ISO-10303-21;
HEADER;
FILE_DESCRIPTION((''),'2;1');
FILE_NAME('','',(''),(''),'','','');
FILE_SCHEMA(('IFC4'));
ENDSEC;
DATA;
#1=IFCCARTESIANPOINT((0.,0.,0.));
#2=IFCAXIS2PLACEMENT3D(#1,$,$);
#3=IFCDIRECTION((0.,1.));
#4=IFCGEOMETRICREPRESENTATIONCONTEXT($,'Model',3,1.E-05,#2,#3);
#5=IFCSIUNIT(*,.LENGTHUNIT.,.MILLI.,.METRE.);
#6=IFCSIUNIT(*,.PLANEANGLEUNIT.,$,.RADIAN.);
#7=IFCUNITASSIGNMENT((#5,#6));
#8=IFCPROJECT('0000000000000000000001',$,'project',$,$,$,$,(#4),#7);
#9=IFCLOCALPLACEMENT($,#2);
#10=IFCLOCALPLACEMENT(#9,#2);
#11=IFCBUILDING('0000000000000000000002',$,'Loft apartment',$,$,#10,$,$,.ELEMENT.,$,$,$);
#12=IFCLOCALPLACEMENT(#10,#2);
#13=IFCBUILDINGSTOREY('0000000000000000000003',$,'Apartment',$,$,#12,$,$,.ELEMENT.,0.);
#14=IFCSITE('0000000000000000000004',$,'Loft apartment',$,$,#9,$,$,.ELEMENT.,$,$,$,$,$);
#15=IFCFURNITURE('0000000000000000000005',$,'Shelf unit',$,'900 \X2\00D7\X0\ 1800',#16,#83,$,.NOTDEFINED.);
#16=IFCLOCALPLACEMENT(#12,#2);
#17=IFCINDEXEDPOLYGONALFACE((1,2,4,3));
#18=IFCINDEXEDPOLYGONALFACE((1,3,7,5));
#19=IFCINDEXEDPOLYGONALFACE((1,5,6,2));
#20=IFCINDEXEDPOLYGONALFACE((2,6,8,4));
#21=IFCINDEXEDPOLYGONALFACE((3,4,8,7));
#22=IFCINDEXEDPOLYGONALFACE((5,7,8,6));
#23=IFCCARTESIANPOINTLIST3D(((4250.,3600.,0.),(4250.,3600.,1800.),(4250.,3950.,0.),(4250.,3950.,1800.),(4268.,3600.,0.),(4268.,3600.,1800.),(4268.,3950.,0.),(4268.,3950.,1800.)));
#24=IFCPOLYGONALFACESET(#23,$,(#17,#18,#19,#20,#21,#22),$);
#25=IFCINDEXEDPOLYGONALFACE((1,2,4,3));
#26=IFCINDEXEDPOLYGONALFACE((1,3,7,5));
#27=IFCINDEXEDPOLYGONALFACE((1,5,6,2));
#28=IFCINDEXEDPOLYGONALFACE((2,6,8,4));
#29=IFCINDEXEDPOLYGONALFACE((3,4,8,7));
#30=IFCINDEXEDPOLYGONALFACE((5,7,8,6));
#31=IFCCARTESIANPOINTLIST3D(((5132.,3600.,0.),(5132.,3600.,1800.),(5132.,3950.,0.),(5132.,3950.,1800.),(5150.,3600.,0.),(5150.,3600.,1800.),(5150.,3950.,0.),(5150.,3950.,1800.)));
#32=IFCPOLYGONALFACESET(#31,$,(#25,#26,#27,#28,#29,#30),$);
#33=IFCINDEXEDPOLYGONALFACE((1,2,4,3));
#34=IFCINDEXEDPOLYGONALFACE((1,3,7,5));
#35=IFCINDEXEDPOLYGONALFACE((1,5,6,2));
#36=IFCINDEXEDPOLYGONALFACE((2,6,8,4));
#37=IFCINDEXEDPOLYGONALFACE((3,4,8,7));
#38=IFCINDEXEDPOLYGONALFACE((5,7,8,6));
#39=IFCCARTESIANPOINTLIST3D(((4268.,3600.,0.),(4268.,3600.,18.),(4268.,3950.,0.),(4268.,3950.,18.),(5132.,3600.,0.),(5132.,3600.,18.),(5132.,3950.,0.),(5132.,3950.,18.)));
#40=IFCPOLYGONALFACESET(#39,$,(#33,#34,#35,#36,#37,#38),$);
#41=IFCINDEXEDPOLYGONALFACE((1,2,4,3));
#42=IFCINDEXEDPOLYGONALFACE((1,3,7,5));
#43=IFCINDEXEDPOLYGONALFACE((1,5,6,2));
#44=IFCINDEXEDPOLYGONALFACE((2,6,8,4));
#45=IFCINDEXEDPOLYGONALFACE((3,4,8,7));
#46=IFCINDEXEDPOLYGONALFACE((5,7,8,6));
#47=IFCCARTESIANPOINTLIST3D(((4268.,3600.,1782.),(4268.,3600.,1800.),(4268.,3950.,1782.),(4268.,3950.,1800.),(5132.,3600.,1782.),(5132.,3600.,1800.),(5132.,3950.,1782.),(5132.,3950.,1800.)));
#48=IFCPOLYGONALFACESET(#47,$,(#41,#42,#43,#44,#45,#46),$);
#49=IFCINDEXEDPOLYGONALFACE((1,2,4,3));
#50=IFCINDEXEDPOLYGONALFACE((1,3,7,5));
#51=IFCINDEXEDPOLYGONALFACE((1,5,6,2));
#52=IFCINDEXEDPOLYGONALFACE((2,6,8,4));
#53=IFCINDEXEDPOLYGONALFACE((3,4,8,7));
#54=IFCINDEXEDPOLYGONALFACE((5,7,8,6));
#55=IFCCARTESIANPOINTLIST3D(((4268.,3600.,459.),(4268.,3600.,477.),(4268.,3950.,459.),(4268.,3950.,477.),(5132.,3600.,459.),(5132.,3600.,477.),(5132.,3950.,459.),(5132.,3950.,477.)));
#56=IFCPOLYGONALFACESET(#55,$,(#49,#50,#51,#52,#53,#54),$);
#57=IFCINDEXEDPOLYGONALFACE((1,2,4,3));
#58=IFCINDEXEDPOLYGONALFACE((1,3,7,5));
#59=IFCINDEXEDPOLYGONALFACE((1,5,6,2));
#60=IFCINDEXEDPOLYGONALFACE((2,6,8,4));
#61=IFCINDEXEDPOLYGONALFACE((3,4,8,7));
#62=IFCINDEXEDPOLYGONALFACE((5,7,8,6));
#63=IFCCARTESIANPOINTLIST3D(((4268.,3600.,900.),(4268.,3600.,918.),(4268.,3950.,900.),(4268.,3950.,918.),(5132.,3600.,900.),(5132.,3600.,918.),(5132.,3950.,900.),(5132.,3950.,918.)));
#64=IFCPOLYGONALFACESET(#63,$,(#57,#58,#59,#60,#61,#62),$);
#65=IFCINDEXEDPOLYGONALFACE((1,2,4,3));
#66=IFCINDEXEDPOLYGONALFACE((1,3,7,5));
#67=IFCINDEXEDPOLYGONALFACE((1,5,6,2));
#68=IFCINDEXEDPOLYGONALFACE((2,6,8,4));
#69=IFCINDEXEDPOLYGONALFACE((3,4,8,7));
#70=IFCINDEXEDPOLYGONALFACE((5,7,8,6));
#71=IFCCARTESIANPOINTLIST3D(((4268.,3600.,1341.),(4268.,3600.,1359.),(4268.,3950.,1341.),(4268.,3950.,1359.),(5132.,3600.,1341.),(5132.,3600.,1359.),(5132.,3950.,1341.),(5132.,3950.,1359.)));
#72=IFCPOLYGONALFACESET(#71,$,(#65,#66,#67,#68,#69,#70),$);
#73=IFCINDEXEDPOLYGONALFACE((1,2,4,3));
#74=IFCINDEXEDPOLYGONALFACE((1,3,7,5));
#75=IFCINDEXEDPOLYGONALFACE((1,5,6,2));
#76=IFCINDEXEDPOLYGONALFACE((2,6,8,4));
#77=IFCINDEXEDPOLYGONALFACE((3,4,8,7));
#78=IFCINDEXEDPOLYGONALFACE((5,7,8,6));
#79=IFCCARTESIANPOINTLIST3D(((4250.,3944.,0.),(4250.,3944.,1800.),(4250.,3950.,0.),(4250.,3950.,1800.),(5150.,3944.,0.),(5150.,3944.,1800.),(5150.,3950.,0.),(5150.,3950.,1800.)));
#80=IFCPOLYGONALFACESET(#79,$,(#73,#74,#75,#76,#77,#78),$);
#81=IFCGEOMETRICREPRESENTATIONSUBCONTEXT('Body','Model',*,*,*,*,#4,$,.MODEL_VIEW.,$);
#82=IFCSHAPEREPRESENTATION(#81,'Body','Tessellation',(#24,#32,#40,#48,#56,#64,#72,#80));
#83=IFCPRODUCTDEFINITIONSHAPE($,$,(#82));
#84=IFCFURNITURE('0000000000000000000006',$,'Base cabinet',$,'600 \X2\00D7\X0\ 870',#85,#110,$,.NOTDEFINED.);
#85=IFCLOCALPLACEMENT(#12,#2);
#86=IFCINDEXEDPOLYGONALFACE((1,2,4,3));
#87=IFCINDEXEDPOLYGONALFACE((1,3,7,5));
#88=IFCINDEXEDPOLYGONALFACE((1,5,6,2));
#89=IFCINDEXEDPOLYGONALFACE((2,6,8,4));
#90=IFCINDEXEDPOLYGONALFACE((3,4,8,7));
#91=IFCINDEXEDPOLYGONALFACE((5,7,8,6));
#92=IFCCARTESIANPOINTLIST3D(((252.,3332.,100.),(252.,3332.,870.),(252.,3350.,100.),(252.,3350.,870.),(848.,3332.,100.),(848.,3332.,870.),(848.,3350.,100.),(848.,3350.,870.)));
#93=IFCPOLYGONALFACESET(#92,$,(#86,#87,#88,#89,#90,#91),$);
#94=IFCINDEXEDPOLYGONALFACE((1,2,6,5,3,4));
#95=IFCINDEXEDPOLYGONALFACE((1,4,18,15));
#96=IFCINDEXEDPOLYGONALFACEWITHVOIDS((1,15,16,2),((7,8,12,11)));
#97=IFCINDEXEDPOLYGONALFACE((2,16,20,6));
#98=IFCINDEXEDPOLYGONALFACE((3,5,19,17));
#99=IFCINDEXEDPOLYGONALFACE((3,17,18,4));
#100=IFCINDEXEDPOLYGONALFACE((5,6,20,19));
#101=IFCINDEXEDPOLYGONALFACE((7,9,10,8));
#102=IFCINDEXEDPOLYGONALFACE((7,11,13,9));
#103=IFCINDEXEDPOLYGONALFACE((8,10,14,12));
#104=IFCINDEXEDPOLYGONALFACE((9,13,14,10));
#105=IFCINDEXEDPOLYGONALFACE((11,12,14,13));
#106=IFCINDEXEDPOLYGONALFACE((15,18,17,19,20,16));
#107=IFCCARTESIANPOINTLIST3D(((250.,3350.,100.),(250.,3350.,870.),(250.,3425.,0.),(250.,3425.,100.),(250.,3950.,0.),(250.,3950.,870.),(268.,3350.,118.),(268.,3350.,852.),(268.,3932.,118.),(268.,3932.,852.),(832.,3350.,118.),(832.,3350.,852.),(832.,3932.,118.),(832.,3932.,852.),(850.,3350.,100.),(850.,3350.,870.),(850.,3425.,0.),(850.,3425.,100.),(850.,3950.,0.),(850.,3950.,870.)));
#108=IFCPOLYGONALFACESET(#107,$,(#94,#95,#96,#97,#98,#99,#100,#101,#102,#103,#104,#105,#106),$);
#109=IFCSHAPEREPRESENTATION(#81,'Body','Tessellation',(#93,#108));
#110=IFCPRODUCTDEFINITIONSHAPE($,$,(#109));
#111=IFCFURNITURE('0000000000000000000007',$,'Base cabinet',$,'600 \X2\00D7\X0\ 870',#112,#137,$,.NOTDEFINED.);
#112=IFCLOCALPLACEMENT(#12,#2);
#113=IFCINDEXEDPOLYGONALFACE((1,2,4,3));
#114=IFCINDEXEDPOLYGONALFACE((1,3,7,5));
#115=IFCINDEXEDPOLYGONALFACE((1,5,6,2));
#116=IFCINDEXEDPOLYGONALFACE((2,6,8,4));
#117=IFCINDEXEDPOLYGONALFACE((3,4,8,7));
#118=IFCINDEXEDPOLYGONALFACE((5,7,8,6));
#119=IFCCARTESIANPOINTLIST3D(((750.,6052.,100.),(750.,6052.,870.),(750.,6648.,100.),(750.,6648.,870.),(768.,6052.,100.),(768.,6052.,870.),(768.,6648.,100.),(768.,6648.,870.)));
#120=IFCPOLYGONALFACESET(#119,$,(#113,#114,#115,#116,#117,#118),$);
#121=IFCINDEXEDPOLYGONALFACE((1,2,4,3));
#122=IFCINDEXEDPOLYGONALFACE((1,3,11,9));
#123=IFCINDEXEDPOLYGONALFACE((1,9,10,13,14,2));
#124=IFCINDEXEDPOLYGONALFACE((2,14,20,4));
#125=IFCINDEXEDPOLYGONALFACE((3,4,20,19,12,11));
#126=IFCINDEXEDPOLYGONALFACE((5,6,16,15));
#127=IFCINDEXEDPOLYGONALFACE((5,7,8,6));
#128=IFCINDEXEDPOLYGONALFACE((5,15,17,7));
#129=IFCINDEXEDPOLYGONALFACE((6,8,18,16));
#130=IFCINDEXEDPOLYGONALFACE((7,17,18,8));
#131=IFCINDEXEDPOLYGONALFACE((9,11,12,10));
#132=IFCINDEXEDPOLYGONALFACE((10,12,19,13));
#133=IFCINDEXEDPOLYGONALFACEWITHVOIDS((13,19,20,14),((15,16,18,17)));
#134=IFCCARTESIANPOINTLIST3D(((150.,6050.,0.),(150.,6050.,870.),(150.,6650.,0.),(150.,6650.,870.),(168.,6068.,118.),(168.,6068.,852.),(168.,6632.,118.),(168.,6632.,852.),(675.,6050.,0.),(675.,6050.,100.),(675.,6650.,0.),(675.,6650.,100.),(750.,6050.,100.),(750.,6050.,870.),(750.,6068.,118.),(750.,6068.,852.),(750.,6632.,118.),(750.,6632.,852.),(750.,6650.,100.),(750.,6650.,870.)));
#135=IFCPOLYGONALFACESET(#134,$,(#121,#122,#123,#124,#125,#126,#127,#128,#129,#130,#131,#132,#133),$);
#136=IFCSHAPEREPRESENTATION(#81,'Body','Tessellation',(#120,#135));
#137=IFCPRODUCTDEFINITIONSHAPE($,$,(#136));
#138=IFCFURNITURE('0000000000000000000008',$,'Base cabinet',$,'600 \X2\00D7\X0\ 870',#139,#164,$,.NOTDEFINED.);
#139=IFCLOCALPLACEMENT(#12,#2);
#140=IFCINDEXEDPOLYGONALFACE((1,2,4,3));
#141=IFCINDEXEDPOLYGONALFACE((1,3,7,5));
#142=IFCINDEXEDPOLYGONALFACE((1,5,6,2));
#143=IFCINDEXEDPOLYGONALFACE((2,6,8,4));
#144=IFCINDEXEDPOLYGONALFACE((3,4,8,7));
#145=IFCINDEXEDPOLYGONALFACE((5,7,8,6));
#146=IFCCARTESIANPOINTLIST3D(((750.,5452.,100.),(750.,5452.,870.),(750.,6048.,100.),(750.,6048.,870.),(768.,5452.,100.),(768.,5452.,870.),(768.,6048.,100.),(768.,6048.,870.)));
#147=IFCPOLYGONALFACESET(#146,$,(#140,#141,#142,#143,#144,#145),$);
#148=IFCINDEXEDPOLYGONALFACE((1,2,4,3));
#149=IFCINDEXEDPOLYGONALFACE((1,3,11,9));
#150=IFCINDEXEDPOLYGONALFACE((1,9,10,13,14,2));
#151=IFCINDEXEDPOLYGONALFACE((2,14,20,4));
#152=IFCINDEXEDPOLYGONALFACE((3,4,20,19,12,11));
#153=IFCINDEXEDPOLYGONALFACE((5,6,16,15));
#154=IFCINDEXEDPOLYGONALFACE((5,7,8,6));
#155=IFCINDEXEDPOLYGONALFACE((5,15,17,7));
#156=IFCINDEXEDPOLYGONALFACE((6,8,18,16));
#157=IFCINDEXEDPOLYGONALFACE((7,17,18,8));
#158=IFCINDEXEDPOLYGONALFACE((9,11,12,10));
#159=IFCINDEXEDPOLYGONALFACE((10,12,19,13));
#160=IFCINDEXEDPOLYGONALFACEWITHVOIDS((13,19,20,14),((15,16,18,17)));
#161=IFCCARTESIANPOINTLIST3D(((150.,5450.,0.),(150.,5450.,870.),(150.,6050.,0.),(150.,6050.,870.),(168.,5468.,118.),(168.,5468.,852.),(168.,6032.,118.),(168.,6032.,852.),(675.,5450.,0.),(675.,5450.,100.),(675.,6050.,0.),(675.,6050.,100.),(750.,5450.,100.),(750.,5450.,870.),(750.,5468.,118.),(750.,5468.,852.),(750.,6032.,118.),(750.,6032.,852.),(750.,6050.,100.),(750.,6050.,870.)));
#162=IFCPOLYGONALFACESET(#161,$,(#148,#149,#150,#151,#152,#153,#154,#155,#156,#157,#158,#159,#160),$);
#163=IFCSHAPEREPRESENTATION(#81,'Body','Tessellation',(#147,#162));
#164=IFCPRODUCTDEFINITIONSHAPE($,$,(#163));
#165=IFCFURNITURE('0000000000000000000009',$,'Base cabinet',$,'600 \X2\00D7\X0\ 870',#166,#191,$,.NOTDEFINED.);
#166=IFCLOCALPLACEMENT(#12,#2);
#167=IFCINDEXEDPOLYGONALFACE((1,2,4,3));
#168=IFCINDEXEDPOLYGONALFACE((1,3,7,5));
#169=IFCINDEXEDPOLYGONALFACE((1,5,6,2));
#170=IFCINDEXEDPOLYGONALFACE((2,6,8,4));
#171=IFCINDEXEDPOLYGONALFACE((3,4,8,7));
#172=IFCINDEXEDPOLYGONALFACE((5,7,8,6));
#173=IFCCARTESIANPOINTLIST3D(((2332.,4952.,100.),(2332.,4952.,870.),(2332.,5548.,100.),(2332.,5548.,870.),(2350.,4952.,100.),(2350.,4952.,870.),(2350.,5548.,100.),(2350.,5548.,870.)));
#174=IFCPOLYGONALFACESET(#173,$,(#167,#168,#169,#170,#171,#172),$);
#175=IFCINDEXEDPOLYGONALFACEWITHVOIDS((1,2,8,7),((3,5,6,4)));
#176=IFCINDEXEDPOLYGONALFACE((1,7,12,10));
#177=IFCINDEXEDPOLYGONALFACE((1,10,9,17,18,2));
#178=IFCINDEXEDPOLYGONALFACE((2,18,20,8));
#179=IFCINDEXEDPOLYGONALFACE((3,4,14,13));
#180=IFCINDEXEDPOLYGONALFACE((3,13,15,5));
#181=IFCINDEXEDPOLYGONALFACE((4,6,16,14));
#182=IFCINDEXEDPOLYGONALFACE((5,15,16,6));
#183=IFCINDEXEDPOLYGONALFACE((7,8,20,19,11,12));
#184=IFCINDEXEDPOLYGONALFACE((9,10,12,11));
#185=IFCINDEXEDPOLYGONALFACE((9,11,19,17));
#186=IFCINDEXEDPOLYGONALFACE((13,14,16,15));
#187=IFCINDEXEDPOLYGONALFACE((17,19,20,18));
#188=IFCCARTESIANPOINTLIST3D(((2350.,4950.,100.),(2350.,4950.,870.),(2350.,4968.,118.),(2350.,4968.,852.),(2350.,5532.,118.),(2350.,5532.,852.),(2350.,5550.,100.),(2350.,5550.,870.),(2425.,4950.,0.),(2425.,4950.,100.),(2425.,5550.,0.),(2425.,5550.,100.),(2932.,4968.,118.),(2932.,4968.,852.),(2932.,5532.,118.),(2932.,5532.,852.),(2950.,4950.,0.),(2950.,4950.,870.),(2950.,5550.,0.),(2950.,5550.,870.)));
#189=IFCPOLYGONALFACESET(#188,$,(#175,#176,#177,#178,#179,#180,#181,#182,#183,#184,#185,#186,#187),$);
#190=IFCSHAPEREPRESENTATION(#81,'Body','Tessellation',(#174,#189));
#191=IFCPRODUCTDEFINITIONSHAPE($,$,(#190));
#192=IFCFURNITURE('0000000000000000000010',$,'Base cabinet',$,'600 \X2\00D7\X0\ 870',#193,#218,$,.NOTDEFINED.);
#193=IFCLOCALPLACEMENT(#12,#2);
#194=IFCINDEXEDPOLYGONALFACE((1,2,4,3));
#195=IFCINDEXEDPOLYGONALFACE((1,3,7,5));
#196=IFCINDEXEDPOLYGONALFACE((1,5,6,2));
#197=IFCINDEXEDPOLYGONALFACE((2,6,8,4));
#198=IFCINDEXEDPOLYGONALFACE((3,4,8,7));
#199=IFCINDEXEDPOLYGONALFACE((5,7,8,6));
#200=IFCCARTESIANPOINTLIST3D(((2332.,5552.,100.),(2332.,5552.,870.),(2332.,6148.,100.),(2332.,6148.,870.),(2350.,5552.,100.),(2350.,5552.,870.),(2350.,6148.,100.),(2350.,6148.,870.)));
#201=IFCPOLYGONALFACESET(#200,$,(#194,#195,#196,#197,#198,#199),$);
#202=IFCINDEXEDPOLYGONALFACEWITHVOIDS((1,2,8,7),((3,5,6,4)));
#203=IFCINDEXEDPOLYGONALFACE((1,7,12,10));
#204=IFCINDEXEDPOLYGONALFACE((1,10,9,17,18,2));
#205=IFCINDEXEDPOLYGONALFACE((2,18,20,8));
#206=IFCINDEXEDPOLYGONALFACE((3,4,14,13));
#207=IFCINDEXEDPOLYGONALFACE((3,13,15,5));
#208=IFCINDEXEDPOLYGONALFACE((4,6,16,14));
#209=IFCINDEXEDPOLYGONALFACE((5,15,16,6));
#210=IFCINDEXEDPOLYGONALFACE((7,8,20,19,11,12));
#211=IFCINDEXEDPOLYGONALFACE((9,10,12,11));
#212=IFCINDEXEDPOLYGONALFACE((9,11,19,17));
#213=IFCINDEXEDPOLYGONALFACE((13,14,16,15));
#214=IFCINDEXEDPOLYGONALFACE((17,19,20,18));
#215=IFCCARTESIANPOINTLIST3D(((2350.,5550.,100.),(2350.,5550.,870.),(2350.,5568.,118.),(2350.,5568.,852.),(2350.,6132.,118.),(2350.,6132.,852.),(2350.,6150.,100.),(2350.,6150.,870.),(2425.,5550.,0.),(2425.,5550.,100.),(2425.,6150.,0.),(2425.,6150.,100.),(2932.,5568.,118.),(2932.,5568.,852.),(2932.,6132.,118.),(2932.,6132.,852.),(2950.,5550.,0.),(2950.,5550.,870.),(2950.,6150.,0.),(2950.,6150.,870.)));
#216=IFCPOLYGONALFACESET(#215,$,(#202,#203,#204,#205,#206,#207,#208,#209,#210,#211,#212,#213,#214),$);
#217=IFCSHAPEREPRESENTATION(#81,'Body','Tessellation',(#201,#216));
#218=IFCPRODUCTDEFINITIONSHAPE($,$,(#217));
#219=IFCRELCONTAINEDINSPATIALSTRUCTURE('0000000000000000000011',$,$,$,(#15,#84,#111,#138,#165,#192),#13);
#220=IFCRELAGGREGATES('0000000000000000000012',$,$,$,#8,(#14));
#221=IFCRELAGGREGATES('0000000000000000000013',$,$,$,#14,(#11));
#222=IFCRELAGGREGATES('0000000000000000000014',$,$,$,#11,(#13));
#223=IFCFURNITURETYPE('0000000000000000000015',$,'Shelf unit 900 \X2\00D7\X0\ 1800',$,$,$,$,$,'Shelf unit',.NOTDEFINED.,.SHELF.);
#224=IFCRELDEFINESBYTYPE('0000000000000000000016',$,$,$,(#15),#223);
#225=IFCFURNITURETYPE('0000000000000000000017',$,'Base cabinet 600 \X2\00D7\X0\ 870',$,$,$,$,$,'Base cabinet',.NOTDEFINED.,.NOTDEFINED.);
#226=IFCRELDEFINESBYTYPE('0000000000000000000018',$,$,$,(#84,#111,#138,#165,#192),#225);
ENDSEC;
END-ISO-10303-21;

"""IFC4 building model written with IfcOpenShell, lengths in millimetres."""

from ifc_helpers import new_model, entity, si_unit, direction, frame, origin, place, context, subcontext, project, spatial, polyline, outline, extrude, source, transform, mapped, type_object, type_shapes, element, save


model = new_model("IFC4")

# Units and contexts
model_context = context("Model", 3, precision=1e-05, world=origin(), true_north=direction((0.0, 1.0)))
body_context = subcontext(model_context, "Body", "Model", "MODEL_VIEW")
ifc_project = project(units=[si_unit("LENGTHUNIT", "METRE", prefix="MILLI"), si_unit("PLANEANGLEUNIT", "RADIAN")], contexts=[model_context])

# Site, building, storey
site_placement = place(None, origin())
site = spatial("IfcSite", under=ifc_project, at=site_placement, Name="Loft apartment", CompositionType="ELEMENT")
building_placement = place(site_placement, origin())
building = spatial("IfcBuilding", under=site, at=building_placement, Name="Loft apartment", CompositionType="ELEMENT")
storey_placement = place(building_placement, origin())
storey = spatial("IfcBuildingStorey", under=building, at=storey_placement, Name="Apartment", CompositionType="ELEMENT", Elevation=0.0)

# Furniture
furniture_type_1 = type_object("IfcFurnitureType", Name="Shelf unit 900 × 1800", ElementType="Shelf unit", AssemblyPlace="NOTDEFINED", PredefinedType="SHELF")
shared_shape_1 = source(origin(), body_context, "Body", "SweptSolid", [
    extrude(outline(polyline([(-450.0, 0.0), (-432.0, 0.0), (-432.0, 350.0), (-450.0, 350.0), (-450.0, 0.0)])), origin(), (0.0, 0.0, 1.0), 1800.0),
    extrude(outline(polyline([(432.0, 0.0), (450.0, 0.0), (450.0, 350.0), (432.0, 350.0), (432.0, 0.0)])), origin(), (0.0, 0.0, 1.0), 1800.0),
    extrude(outline(polyline([(-432.0, 0.0), (432.0, 0.0), (432.0, 350.0), (-432.0, 350.0), (-432.0, 0.0)])), origin(), (0.0, 0.0, 1.0), 18.0),
    extrude(outline(polyline([(-432.0, 0.0), (432.0, 0.0), (432.0, 350.0), (-432.0, 350.0), (-432.0, 0.0)])), frame((0.0, 0.0, 1782.0)), (0.0, 0.0, 1.0), 18.0),
    extrude(outline(polyline([(-432.0, 0.0), (432.0, 0.0), (432.0, 350.0), (-432.0, 350.0), (-432.0, 0.0)])), frame((0.0, 0.0, 459.0)), (0.0, 0.0, 1.0), 18.0),
    extrude(outline(polyline([(-432.0, 0.0), (432.0, 0.0), (432.0, 350.0), (-432.0, 350.0), (-432.0, 0.0)])), frame((0.0, 0.0, 900.0)), (0.0, 0.0, 1.0), 18.0),
    extrude(outline(polyline([(-432.0, 0.0), (432.0, 0.0), (432.0, 350.0), (-432.0, 350.0), (-432.0, 0.0)])), frame((0.0, 0.0, 1341.0)), (0.0, 0.0, 1.0), 18.0),
    extrude(outline(polyline([(-450.0, 344.0), (450.0, 344.0), (450.0, 350.0), (-450.0, 350.0), (-450.0, 344.0)])), origin(), (0.0, 0.0, 1.0), 1800.0),
])
type_shapes(furniture_type_1, [shared_shape_1])
furniture_1_placement = place(storey_placement, frame((4700.0, 3600.0, 0.0), z_axis=(0.0, 0.0, 1.0), x_axis=(1.0, 0.0, 0.0)))
element("IfcFurniture", 1, at=furniture_1_placement, inside=storey, type_object=furniture_type_1, Name="Shelf unit", ObjectType="900 × 1800", PredefinedType="NOTDEFINED", context=body_context, shape_type="MappedRepresentation", body=[
    mapped(shared_shape_1, transform((0.0, 0.0, 0.0))),
])
furniture_type_2 = type_object("IfcFurnitureType", Name="Base cabinet 600 × 870", ElementType="Base cabinet", AssemblyPlace="NOTDEFINED", PredefinedType="NOTDEFINED")
cartesian_point_1 = entity("IfcCartesianPoint", [-300.0, 0.0])
cartesian_point_2 = entity("IfcCartesianPoint", [-282.0, -1.0])
cartesian_point_3 = entity("IfcCartesianPoint", [-301.0, -1.0])
shared_shape_2 = source(origin(), body_context, "Body", "SolidModel", [
    extrude(outline(polyline([(-298.0, -18.0), (298.0, -18.0), (298.0, 0.0), (-298.0, 0.0), (-298.0, -18.0)])), frame((0.0, 0.0, 100.0)), (0.0, 0.0, 1.0), 770.0),
    entity("IfcCsgSolid", entity("IfcBooleanResult", "DIFFERENCE", entity("IfcBooleanResult", "DIFFERENCE", entity("IfcExtrudedAreaSolid", entity("IfcArbitraryClosedProfileDef", "AREA", None, entity("IfcPolyline", [cartesian_point_1, entity("IfcCartesianPoint", [300.0, 0.0]), entity("IfcCartesianPoint", [300.0, 600.0]), entity("IfcCartesianPoint", [-300.0, 600.0]), cartesian_point_1])), entity("IfcAxis2Placement3D", entity("IfcCartesianPoint", [0.0, 0.0, 0.0])), entity("IfcDirection", [0.0, 0.0, 1.0]), 870.0), entity("IfcExtrudedAreaSolid", entity("IfcArbitraryClosedProfileDef", "AREA", None, entity("IfcPolyline", [cartesian_point_2, entity("IfcCartesianPoint", [282.0, -1.0]), entity("IfcCartesianPoint", [282.0, 582.0]), entity("IfcCartesianPoint", [-282.0, 582.0]), cartesian_point_2])), entity("IfcAxis2Placement3D", entity("IfcCartesianPoint", [0.0, 0.0, 118.0])), entity("IfcDirection", [0.0, 0.0, 1.0]), 734.0)), entity("IfcExtrudedAreaSolid", entity("IfcArbitraryClosedProfileDef", "AREA", None, entity("IfcPolyline", [cartesian_point_3, entity("IfcCartesianPoint", [301.0, -1.0]), entity("IfcCartesianPoint", [301.0, 75.0]), entity("IfcCartesianPoint", [-301.0, 75.0]), cartesian_point_3])), entity("IfcAxis2Placement3D", entity("IfcCartesianPoint", [0.0, 0.0, -1.0])), entity("IfcDirection", [0.0, 0.0, 1.0]), 101.0))),
])
type_shapes(furniture_type_2, [shared_shape_2])
for number, where, z_axis, x_axis, name in (
    (2, (550.0, 3350.0, 0.0), (0.0, 0.0, 1.0), (1.0, 0.0, 0.0), "Base cabinet"),
    (3, (750.0, 6350.0, 0.0), (0.0, 0.0, 1.0), (0.0, 1.0, 0.0), "Base cabinet"),
    (4, (750.0, 5750.0, 0.0), (0.0, 0.0, 1.0), (0.0, 1.0, 0.0), "Base cabinet"),
    (5, (2350.0, 5250.0, 0.0), (0.0, 0.0, 1.0), (0.0, -1.0, 0.0), "Base cabinet"),
    (6, (2350.0, 5850.0, 0.0), (0.0, 0.0, 1.0), (0.0, -1.0, 0.0), "Base cabinet"),
):
    element("IfcFurniture", number, at=place(storey_placement, frame(where, z_axis=z_axis, x_axis=x_axis)), inside=storey, type_object=furniture_type_2, Name=name, ObjectType="600 × 870", PredefinedType="NOTDEFINED", context=body_context, shape_type="MappedRepresentation", body=[
        mapped(shared_shape_2, transform((0.0, 0.0, 0.0))),
    ])

save(model, "model.ifc")
